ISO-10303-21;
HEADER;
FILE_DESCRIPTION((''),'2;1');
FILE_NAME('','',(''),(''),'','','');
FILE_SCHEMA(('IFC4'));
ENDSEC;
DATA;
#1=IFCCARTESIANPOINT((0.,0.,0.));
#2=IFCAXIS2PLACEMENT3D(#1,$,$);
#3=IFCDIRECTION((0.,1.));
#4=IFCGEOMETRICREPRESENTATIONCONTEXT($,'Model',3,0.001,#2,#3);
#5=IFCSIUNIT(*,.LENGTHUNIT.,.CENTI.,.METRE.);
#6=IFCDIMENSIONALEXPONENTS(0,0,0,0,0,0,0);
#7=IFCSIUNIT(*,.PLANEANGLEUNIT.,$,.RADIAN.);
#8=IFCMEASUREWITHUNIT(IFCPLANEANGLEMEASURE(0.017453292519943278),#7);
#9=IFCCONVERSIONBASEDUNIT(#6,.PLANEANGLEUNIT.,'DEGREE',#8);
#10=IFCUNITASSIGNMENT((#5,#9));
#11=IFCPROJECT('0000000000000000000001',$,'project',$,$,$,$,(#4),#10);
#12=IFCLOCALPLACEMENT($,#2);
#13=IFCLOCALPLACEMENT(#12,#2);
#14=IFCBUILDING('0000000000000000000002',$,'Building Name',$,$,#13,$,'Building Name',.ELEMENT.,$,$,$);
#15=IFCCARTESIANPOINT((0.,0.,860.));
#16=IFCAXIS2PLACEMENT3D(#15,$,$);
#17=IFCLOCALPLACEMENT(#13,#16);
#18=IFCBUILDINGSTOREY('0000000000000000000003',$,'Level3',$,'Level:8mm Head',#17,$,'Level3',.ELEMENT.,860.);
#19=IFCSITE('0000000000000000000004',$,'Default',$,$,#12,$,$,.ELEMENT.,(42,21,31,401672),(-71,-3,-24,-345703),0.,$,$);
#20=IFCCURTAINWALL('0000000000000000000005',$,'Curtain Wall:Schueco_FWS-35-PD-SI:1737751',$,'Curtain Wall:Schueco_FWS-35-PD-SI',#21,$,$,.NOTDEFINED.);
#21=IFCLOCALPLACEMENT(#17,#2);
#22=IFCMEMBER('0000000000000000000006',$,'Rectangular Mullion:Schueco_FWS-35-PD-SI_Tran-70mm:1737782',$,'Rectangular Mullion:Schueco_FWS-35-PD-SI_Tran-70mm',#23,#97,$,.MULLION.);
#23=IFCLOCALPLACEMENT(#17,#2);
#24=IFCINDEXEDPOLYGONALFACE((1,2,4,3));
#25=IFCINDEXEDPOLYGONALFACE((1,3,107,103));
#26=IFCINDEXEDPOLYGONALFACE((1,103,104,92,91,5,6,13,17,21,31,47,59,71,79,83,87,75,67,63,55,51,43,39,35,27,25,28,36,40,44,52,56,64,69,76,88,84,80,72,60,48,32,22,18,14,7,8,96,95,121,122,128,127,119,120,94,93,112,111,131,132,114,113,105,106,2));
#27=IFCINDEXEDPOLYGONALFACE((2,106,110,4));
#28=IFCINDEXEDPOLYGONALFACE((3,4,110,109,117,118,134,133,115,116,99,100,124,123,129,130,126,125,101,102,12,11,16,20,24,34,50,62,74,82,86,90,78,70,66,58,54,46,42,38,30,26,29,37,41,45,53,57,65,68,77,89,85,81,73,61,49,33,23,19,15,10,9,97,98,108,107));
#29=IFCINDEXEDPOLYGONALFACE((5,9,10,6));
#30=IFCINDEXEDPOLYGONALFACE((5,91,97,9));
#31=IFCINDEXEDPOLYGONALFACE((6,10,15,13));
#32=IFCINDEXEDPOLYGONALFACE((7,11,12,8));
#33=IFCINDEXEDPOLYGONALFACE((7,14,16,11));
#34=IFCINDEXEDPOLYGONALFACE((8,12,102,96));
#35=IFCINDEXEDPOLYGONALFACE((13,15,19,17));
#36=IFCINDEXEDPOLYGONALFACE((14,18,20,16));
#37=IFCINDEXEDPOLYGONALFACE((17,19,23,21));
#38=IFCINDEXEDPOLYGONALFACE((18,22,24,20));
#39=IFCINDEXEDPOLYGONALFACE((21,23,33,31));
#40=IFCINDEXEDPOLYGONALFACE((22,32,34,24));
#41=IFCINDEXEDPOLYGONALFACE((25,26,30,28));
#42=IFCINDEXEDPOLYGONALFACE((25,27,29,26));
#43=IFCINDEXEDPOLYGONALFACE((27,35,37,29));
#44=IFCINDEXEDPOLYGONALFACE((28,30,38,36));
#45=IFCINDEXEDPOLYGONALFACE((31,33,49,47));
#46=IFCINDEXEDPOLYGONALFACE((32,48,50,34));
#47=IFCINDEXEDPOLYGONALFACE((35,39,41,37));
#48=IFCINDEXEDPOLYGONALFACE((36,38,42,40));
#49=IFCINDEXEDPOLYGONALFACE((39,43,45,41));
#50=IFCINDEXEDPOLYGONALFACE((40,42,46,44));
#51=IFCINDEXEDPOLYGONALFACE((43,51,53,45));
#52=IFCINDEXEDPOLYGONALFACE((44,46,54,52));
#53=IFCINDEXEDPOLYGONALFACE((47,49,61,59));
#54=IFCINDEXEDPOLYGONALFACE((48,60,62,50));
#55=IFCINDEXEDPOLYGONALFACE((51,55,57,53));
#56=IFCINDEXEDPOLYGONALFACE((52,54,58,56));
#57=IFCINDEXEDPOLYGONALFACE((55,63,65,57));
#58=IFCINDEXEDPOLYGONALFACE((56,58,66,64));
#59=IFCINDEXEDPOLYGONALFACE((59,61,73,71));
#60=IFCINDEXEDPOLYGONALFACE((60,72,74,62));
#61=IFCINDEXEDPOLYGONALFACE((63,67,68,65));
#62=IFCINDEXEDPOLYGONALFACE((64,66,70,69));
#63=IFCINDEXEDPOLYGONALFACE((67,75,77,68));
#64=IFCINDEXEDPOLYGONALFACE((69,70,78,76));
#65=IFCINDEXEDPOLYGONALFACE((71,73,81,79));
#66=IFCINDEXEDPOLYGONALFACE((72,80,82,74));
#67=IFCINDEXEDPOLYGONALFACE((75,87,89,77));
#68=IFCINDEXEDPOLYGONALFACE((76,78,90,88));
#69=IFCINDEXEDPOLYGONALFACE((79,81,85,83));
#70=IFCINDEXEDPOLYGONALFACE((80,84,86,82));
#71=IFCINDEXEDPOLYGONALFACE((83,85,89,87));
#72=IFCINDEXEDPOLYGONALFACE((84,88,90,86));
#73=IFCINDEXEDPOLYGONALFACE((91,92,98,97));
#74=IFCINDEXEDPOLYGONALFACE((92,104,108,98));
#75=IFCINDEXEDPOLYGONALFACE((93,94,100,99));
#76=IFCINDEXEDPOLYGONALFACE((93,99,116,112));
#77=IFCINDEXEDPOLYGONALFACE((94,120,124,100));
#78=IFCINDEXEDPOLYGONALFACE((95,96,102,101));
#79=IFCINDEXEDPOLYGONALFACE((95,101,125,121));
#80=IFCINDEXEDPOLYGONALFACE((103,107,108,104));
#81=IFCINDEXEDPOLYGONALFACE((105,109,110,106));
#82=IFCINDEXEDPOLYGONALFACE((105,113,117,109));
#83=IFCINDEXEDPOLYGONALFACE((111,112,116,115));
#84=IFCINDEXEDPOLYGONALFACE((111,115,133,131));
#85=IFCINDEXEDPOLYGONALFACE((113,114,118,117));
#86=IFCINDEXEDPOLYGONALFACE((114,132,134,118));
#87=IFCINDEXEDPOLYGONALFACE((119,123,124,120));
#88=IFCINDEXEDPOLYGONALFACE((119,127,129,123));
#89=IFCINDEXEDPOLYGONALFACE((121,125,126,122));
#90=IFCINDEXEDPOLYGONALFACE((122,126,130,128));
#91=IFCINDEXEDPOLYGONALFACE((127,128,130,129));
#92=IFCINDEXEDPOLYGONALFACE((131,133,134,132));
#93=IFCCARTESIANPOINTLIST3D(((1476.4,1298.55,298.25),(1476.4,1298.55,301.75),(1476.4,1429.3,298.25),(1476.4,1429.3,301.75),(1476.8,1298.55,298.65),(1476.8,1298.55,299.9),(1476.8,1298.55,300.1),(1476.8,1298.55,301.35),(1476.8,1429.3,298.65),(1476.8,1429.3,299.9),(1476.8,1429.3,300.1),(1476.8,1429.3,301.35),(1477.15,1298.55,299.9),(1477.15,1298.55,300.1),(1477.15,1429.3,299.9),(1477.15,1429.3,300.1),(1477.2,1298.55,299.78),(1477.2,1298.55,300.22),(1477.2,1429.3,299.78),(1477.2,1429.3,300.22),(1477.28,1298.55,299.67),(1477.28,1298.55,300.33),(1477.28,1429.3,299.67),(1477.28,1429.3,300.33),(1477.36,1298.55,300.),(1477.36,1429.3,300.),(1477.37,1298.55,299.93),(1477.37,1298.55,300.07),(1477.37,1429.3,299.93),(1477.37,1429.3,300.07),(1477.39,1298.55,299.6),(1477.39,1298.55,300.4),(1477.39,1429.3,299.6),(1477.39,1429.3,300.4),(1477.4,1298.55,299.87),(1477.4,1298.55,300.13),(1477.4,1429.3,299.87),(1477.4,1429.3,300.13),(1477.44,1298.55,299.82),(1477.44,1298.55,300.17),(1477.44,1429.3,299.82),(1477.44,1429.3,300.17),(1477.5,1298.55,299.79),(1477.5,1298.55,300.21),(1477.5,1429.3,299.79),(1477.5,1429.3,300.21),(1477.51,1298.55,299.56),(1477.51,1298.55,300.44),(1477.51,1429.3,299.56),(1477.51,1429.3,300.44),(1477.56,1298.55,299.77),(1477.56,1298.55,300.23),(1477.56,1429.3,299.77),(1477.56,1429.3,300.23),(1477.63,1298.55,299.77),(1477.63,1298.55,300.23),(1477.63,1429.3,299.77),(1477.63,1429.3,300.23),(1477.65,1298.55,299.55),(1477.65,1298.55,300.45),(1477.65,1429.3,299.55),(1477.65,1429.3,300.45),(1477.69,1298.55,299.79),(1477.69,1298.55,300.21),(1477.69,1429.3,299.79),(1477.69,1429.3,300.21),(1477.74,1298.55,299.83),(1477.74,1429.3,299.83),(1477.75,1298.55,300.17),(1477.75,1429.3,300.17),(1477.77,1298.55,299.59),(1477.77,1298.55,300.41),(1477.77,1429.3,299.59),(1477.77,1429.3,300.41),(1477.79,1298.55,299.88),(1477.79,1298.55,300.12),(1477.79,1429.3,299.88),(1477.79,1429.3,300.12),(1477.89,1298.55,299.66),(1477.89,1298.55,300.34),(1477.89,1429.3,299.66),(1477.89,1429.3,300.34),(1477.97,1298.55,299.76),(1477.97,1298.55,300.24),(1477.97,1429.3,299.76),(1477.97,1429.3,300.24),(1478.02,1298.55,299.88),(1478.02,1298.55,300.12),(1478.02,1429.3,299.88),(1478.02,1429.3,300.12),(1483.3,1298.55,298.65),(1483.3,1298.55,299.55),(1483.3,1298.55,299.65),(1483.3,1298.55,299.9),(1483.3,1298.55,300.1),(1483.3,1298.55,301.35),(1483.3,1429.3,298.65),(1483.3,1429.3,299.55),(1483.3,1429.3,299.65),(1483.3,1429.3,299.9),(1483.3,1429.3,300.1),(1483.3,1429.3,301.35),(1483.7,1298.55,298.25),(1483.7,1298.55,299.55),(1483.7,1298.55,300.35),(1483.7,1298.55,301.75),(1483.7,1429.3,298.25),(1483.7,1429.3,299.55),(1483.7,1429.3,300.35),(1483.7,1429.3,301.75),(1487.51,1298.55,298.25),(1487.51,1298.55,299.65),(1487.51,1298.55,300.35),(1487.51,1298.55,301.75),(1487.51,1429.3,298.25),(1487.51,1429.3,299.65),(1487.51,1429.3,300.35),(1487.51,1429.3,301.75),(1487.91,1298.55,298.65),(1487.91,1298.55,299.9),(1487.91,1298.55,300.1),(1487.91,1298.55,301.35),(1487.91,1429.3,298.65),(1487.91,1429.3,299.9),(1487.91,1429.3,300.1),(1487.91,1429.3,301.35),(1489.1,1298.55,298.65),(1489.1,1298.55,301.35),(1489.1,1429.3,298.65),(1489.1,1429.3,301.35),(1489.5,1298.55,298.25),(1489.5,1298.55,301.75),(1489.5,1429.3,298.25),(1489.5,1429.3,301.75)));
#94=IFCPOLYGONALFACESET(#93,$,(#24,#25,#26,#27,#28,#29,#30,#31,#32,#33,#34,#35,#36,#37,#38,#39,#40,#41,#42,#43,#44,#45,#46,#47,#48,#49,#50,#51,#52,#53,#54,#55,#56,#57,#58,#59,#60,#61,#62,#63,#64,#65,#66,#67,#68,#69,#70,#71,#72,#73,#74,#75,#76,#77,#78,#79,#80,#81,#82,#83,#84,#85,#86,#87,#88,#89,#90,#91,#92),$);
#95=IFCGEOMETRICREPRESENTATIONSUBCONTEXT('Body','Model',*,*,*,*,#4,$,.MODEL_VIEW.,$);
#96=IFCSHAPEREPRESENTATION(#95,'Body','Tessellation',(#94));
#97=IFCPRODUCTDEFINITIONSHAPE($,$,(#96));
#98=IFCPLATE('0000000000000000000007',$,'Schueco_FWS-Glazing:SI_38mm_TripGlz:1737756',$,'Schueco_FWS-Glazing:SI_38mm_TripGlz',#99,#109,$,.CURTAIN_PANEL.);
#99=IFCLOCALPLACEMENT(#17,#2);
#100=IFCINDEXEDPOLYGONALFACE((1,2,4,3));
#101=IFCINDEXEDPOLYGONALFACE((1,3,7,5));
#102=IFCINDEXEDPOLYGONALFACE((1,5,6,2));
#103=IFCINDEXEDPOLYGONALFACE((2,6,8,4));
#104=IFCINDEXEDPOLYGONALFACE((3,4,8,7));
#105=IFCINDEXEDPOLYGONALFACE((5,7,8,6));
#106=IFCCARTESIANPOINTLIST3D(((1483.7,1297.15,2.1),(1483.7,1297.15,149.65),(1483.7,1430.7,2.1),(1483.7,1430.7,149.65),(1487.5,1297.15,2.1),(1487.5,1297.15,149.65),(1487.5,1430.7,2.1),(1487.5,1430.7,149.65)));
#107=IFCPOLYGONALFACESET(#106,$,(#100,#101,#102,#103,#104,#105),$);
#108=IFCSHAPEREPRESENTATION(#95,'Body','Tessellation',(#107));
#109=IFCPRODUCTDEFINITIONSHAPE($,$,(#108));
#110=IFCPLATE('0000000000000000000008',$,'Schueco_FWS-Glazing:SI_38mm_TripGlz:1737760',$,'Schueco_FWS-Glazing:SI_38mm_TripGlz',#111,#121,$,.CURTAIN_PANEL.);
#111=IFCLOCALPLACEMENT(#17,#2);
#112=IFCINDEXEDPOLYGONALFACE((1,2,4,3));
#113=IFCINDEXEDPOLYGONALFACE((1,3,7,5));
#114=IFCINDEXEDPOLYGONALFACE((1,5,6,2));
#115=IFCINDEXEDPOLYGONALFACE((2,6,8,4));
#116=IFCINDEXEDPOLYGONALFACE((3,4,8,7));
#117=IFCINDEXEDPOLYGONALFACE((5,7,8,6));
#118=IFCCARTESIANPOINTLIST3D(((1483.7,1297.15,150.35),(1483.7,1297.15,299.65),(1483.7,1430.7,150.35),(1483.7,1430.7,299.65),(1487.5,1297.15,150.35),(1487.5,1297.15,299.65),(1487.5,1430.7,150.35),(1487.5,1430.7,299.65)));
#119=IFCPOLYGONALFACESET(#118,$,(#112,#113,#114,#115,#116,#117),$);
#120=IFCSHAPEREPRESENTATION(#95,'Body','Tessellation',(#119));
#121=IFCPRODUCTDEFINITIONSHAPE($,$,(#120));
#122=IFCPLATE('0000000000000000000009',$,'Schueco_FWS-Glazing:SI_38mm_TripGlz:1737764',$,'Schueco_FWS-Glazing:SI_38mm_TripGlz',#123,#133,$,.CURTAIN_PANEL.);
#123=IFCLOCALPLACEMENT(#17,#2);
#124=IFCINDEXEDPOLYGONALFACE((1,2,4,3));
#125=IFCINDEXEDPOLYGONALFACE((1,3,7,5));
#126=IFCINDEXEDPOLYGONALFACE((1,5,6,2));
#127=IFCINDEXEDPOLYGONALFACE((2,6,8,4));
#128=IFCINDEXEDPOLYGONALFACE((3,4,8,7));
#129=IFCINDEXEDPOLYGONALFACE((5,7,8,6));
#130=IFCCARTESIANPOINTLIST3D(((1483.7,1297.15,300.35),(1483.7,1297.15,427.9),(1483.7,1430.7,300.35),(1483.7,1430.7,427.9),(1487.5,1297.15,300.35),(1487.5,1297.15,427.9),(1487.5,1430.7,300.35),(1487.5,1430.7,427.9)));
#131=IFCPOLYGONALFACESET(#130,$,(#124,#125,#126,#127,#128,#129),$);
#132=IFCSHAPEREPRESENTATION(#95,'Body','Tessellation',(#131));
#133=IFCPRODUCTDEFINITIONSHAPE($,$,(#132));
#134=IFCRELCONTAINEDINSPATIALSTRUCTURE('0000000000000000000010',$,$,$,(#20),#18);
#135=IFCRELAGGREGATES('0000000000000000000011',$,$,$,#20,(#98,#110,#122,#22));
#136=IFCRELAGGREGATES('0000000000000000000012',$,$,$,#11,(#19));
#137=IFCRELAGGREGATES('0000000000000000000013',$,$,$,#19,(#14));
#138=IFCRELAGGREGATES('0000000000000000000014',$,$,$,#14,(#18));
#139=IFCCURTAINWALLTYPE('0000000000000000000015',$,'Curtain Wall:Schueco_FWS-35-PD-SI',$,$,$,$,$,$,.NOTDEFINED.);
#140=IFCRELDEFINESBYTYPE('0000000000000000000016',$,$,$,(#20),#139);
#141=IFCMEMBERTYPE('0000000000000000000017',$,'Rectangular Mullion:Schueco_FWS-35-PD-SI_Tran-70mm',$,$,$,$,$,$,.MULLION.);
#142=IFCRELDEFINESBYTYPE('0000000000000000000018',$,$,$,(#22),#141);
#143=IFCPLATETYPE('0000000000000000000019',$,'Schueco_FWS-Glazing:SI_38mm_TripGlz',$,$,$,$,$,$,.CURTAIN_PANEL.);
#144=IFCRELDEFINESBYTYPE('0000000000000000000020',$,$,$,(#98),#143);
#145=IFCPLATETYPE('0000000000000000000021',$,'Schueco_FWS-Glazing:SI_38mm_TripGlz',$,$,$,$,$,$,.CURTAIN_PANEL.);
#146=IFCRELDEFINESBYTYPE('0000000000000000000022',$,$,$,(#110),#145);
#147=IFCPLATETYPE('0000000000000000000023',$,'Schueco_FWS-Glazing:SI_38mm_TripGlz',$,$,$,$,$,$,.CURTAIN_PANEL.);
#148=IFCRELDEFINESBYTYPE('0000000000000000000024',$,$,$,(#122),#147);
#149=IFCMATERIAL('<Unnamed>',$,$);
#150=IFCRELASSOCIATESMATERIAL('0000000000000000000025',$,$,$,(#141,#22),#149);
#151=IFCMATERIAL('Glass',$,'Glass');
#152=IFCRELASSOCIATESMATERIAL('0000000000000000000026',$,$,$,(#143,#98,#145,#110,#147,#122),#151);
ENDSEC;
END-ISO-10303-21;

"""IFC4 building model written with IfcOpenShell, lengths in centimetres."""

from ifc_helpers import new_model, entity, si_unit, converted_unit, direction, frame, origin, place, context, subcontext, project, spatial, line, arc, indexed_curve, outline, extrude, source, transform, mapped, material, type_object, type_shapes, element, aggregate, save


model = new_model("IFC4")

# Units and contexts
model_context = context("Model", 3, precision=0.001, world=origin(), true_north=direction((0.0, 1.0)))
body_context = subcontext(model_context, "Body", "Model", "MODEL_VIEW")
ifc_project = project(units=[si_unit("LENGTHUNIT", "METRE", prefix="CENTI"), converted_unit("PLANEANGLEUNIT", "DEGREE", entity("IfcPlaneAngleMeasure", 0.017453292519943278), si_unit("PLANEANGLEUNIT", "RADIAN"), dimensions=[0, 0, 0, 0, 0, 0, 0])], contexts=[model_context])

# Site, building, storey
site_placement = place(None, origin())
site = spatial("IfcSite", under=ifc_project, at=site_placement, Name="Default", CompositionType="ELEMENT", RefLatitude=(42, 21, 31, 401672), RefLongitude=(-71, -3, -24, -345703), RefElevation=0.0)
building_placement = place(site_placement, origin())
building = spatial("IfcBuilding", under=site, at=building_placement, Name="Building Name", LongName="Building Name", CompositionType="ELEMENT")
storey_placement = place(building_placement, frame((0.0, 0.0, 860.0)))
storey = spatial("IfcBuildingStorey", under=building, at=storey_placement, Name="Level3", ObjectType="Level:8mm Head", LongName="Level3", CompositionType="ELEMENT", Elevation=860.0)

# Curtain wall, member, plates
curtain_wall_type = type_object("IfcCurtainWallType", Name="Curtain Wall:Schueco_FWS-35-PD-SI", PredefinedType="NOTDEFINED")
curtain_wall_placement = place(storey_placement, frame((0.0, 0.0, -860.0)))
curtain_wall = element("IfcCurtainWall", 1, at=curtain_wall_placement, inside=storey, type_object=curtain_wall_type, Name="Curtain Wall:Schueco_FWS-35-PD-SI:1737751", ObjectType="Curtain Wall:Schueco_FWS-35-PD-SI", PredefinedType="NOTDEFINED")
ifc_material_1 = material(Name="<Unnamed>")
member_type_1 = type_object("IfcMemberType", Name="Rectangular Mullion:Schueco_FWS-35-PD-SI_Tran-70mm", PredefinedType="MULLION", material=ifc_material_1)
shared_shape_1 = source(origin(), body_context, "Body", "SweptSolid", [
    extrude(outline(indexed_curve([(-1.78, -6.52), (1.72, -6.52), (1.72, 0.78), (0.42, 0.78), (0.42, 0.38), (1.32, 0.38), (1.32, -6.12), (0.07, -6.12), (0.07, -5.77), (0.42, -5.34), (0.09, -4.9), (0.09, -5.14), (-0.03, -5.56), (-0.15, -5.14), (-0.15, -4.9), (-0.48, -5.34), (-0.13, -5.77), (-0.13, -6.12), (-1.38, -6.12), (-1.38, 0.38), (-0.13, 0.38), (-0.13, 4.99), (-1.38, 4.99), (-1.38, 6.18), (1.32, 6.18), (1.32, 4.99), (0.07, 4.99), (0.07, 0.38), (0.32, 0.38), (0.32, 4.59), (1.72, 4.59), (1.72, 6.58), (-1.78, 6.58), (-1.78, 4.59), (-0.38, 4.59), (-0.38, 0.78), (-1.78, 0.78)], segments=[line(1, 2, 3, 4, 5, 6, 7, 8, 9), arc(9, 10, 11), line(11, 12), arc(12, 13, 14), line(14, 15), arc(15, 16, 17), line(17, 18, 19, 20, 21, 22, 23, 24, 25, 26, 27, 28, 29, 30, 31, 32, 33, 34, 35, 36, 37, 1)], self_intersect=False)), frame((-0.03, 4.58, -130.75), z_axis=(0.0, 0.0, 1.0), x_axis=(-1.0, 0.0, 0.0)), (0.0, 0.0, 1.0), 130.75),
])
type_shapes(member_type_1, [shared_shape_1])
member_1_placement = place(curtain_wall_placement, frame((1487.5, 1298.55, 1160.0), z_axis=(0.0, -1.0, 0.0), x_axis=(0.0, 0.0, 1.0)))
member_1 = element("IfcMember", 2, at=member_1_placement, type_object=member_type_1, material=ifc_material_1, Name="Rectangular Mullion:Schueco_FWS-35-PD-SI_Tran-70mm:1737782", ObjectType="Rectangular Mullion:Schueco_FWS-35-PD-SI_Tran-70mm", PredefinedType="MULLION", context=body_context, shape_type="MappedRepresentation", body=[
    mapped(shared_shape_1, transform((0.0, 0.0, 0.0), scale=1.0)),
])
ifc_material_2 = material(Name="Glass", Category="Glass")
plate_type_1 = type_object("IfcPlateType", Name="Schueco_FWS-Glazing:SI_38mm_TripGlz", PredefinedType="CURTAIN_PANEL", material=ifc_material_2)
shared_shape_2 = source(origin(), body_context, "Body", "SweptSolid", [
    extrude(outline(indexed_curve([(-1.9, -66.78), (1.9, -66.78), (1.9, 66.78), (-1.9, 66.78), (-1.9, -66.78)], self_intersect=False)), frame((0.0, -1.9, 0.0), z_axis=(0.0, 0.0, 1.0), x_axis=(0.0, 1.0, 0.0)), (0.0, 0.0, 1.0), 147.55),
])
type_shapes(plate_type_1, [shared_shape_2])
plate_1_placement = place(curtain_wall_placement, frame((1487.5, 1363.92, 862.1), z_axis=(0.0, 0.0, 1.0), x_axis=(0.0, -1.0, 0.0)))
plate_1 = element("IfcPlate", 3, at=plate_1_placement, type_object=plate_type_1, material=ifc_material_2, Name="Schueco_FWS-Glazing:SI_38mm_TripGlz:1737756", ObjectType="Schueco_FWS-Glazing:SI_38mm_TripGlz", PredefinedType="CURTAIN_PANEL", context=body_context, shape_type="MappedRepresentation", body=[
    mapped(shared_shape_2, transform((0.0, 0.0, 0.0), scale=1.0)),
])
plate_type_2 = type_object("IfcPlateType", Name="Schueco_FWS-Glazing:SI_38mm_TripGlz", PredefinedType="CURTAIN_PANEL", material=ifc_material_2)
shared_shape_3 = source(origin(), body_context, "Body", "SweptSolid", [
    extrude(outline(indexed_curve([(-1.9, -66.78), (1.9, -66.78), (1.9, 66.78), (-1.9, 66.78), (-1.9, -66.78)], self_intersect=False)), frame((0.0, -1.9, 0.0), z_axis=(0.0, 0.0, 1.0), x_axis=(0.0, 1.0, 0.0)), (0.0, 0.0, 1.0), 149.3),
])
type_shapes(plate_type_2, [shared_shape_3])
plate_2_placement = place(curtain_wall_placement, frame((1487.5, 1363.92, 1010.35), z_axis=(0.0, 0.0, 1.0), x_axis=(0.0, -1.0, 0.0)))
plate_2 = element("IfcPlate", 4, at=plate_2_placement, type_object=plate_type_2, material=ifc_material_2, Name="Schueco_FWS-Glazing:SI_38mm_TripGlz:1737760", ObjectType="Schueco_FWS-Glazing:SI_38mm_TripGlz", PredefinedType="CURTAIN_PANEL", context=body_context, shape_type="MappedRepresentation", body=[
    mapped(shared_shape_3, transform((0.0, 0.0, 0.0), scale=1.0)),
])
plate_type_3 = type_object("IfcPlateType", Name="Schueco_FWS-Glazing:SI_38mm_TripGlz", PredefinedType="CURTAIN_PANEL", material=ifc_material_2)
shared_shape_4 = source(origin(), body_context, "Body", "SweptSolid", [
    extrude(outline(indexed_curve([(-1.9, -66.77), (1.9, -66.77), (1.9, 66.77), (-1.9, 66.77), (-1.9, -66.77)], self_intersect=False)), frame((0.0, -1.9, 0.0), z_axis=(0.0, 0.0, 1.0), x_axis=(0.0, 1.0, 0.0)), (0.0, 0.0, 1.0), 127.55),
])
type_shapes(plate_type_3, [shared_shape_4])
plate_3_placement = place(curtain_wall_placement, frame((1487.5, 1363.92, 1160.35), z_axis=(0.0, 0.0, 1.0), x_axis=(0.0, -1.0, 0.0)))
plate_3 = element("IfcPlate", 5, at=plate_3_placement, type_object=plate_type_3, material=ifc_material_2, Name="Schueco_FWS-Glazing:SI_38mm_TripGlz:1737764", ObjectType="Schueco_FWS-Glazing:SI_38mm_TripGlz", PredefinedType="CURTAIN_PANEL", context=body_context, shape_type="MappedRepresentation", body=[
    mapped(shared_shape_4, transform((0.0, 0.0, 0.0), scale=1.0)),
])
aggregate(curtain_wall, [plate_1, plate_2, plate_3, member_1])

save(model, "model.ifc")
